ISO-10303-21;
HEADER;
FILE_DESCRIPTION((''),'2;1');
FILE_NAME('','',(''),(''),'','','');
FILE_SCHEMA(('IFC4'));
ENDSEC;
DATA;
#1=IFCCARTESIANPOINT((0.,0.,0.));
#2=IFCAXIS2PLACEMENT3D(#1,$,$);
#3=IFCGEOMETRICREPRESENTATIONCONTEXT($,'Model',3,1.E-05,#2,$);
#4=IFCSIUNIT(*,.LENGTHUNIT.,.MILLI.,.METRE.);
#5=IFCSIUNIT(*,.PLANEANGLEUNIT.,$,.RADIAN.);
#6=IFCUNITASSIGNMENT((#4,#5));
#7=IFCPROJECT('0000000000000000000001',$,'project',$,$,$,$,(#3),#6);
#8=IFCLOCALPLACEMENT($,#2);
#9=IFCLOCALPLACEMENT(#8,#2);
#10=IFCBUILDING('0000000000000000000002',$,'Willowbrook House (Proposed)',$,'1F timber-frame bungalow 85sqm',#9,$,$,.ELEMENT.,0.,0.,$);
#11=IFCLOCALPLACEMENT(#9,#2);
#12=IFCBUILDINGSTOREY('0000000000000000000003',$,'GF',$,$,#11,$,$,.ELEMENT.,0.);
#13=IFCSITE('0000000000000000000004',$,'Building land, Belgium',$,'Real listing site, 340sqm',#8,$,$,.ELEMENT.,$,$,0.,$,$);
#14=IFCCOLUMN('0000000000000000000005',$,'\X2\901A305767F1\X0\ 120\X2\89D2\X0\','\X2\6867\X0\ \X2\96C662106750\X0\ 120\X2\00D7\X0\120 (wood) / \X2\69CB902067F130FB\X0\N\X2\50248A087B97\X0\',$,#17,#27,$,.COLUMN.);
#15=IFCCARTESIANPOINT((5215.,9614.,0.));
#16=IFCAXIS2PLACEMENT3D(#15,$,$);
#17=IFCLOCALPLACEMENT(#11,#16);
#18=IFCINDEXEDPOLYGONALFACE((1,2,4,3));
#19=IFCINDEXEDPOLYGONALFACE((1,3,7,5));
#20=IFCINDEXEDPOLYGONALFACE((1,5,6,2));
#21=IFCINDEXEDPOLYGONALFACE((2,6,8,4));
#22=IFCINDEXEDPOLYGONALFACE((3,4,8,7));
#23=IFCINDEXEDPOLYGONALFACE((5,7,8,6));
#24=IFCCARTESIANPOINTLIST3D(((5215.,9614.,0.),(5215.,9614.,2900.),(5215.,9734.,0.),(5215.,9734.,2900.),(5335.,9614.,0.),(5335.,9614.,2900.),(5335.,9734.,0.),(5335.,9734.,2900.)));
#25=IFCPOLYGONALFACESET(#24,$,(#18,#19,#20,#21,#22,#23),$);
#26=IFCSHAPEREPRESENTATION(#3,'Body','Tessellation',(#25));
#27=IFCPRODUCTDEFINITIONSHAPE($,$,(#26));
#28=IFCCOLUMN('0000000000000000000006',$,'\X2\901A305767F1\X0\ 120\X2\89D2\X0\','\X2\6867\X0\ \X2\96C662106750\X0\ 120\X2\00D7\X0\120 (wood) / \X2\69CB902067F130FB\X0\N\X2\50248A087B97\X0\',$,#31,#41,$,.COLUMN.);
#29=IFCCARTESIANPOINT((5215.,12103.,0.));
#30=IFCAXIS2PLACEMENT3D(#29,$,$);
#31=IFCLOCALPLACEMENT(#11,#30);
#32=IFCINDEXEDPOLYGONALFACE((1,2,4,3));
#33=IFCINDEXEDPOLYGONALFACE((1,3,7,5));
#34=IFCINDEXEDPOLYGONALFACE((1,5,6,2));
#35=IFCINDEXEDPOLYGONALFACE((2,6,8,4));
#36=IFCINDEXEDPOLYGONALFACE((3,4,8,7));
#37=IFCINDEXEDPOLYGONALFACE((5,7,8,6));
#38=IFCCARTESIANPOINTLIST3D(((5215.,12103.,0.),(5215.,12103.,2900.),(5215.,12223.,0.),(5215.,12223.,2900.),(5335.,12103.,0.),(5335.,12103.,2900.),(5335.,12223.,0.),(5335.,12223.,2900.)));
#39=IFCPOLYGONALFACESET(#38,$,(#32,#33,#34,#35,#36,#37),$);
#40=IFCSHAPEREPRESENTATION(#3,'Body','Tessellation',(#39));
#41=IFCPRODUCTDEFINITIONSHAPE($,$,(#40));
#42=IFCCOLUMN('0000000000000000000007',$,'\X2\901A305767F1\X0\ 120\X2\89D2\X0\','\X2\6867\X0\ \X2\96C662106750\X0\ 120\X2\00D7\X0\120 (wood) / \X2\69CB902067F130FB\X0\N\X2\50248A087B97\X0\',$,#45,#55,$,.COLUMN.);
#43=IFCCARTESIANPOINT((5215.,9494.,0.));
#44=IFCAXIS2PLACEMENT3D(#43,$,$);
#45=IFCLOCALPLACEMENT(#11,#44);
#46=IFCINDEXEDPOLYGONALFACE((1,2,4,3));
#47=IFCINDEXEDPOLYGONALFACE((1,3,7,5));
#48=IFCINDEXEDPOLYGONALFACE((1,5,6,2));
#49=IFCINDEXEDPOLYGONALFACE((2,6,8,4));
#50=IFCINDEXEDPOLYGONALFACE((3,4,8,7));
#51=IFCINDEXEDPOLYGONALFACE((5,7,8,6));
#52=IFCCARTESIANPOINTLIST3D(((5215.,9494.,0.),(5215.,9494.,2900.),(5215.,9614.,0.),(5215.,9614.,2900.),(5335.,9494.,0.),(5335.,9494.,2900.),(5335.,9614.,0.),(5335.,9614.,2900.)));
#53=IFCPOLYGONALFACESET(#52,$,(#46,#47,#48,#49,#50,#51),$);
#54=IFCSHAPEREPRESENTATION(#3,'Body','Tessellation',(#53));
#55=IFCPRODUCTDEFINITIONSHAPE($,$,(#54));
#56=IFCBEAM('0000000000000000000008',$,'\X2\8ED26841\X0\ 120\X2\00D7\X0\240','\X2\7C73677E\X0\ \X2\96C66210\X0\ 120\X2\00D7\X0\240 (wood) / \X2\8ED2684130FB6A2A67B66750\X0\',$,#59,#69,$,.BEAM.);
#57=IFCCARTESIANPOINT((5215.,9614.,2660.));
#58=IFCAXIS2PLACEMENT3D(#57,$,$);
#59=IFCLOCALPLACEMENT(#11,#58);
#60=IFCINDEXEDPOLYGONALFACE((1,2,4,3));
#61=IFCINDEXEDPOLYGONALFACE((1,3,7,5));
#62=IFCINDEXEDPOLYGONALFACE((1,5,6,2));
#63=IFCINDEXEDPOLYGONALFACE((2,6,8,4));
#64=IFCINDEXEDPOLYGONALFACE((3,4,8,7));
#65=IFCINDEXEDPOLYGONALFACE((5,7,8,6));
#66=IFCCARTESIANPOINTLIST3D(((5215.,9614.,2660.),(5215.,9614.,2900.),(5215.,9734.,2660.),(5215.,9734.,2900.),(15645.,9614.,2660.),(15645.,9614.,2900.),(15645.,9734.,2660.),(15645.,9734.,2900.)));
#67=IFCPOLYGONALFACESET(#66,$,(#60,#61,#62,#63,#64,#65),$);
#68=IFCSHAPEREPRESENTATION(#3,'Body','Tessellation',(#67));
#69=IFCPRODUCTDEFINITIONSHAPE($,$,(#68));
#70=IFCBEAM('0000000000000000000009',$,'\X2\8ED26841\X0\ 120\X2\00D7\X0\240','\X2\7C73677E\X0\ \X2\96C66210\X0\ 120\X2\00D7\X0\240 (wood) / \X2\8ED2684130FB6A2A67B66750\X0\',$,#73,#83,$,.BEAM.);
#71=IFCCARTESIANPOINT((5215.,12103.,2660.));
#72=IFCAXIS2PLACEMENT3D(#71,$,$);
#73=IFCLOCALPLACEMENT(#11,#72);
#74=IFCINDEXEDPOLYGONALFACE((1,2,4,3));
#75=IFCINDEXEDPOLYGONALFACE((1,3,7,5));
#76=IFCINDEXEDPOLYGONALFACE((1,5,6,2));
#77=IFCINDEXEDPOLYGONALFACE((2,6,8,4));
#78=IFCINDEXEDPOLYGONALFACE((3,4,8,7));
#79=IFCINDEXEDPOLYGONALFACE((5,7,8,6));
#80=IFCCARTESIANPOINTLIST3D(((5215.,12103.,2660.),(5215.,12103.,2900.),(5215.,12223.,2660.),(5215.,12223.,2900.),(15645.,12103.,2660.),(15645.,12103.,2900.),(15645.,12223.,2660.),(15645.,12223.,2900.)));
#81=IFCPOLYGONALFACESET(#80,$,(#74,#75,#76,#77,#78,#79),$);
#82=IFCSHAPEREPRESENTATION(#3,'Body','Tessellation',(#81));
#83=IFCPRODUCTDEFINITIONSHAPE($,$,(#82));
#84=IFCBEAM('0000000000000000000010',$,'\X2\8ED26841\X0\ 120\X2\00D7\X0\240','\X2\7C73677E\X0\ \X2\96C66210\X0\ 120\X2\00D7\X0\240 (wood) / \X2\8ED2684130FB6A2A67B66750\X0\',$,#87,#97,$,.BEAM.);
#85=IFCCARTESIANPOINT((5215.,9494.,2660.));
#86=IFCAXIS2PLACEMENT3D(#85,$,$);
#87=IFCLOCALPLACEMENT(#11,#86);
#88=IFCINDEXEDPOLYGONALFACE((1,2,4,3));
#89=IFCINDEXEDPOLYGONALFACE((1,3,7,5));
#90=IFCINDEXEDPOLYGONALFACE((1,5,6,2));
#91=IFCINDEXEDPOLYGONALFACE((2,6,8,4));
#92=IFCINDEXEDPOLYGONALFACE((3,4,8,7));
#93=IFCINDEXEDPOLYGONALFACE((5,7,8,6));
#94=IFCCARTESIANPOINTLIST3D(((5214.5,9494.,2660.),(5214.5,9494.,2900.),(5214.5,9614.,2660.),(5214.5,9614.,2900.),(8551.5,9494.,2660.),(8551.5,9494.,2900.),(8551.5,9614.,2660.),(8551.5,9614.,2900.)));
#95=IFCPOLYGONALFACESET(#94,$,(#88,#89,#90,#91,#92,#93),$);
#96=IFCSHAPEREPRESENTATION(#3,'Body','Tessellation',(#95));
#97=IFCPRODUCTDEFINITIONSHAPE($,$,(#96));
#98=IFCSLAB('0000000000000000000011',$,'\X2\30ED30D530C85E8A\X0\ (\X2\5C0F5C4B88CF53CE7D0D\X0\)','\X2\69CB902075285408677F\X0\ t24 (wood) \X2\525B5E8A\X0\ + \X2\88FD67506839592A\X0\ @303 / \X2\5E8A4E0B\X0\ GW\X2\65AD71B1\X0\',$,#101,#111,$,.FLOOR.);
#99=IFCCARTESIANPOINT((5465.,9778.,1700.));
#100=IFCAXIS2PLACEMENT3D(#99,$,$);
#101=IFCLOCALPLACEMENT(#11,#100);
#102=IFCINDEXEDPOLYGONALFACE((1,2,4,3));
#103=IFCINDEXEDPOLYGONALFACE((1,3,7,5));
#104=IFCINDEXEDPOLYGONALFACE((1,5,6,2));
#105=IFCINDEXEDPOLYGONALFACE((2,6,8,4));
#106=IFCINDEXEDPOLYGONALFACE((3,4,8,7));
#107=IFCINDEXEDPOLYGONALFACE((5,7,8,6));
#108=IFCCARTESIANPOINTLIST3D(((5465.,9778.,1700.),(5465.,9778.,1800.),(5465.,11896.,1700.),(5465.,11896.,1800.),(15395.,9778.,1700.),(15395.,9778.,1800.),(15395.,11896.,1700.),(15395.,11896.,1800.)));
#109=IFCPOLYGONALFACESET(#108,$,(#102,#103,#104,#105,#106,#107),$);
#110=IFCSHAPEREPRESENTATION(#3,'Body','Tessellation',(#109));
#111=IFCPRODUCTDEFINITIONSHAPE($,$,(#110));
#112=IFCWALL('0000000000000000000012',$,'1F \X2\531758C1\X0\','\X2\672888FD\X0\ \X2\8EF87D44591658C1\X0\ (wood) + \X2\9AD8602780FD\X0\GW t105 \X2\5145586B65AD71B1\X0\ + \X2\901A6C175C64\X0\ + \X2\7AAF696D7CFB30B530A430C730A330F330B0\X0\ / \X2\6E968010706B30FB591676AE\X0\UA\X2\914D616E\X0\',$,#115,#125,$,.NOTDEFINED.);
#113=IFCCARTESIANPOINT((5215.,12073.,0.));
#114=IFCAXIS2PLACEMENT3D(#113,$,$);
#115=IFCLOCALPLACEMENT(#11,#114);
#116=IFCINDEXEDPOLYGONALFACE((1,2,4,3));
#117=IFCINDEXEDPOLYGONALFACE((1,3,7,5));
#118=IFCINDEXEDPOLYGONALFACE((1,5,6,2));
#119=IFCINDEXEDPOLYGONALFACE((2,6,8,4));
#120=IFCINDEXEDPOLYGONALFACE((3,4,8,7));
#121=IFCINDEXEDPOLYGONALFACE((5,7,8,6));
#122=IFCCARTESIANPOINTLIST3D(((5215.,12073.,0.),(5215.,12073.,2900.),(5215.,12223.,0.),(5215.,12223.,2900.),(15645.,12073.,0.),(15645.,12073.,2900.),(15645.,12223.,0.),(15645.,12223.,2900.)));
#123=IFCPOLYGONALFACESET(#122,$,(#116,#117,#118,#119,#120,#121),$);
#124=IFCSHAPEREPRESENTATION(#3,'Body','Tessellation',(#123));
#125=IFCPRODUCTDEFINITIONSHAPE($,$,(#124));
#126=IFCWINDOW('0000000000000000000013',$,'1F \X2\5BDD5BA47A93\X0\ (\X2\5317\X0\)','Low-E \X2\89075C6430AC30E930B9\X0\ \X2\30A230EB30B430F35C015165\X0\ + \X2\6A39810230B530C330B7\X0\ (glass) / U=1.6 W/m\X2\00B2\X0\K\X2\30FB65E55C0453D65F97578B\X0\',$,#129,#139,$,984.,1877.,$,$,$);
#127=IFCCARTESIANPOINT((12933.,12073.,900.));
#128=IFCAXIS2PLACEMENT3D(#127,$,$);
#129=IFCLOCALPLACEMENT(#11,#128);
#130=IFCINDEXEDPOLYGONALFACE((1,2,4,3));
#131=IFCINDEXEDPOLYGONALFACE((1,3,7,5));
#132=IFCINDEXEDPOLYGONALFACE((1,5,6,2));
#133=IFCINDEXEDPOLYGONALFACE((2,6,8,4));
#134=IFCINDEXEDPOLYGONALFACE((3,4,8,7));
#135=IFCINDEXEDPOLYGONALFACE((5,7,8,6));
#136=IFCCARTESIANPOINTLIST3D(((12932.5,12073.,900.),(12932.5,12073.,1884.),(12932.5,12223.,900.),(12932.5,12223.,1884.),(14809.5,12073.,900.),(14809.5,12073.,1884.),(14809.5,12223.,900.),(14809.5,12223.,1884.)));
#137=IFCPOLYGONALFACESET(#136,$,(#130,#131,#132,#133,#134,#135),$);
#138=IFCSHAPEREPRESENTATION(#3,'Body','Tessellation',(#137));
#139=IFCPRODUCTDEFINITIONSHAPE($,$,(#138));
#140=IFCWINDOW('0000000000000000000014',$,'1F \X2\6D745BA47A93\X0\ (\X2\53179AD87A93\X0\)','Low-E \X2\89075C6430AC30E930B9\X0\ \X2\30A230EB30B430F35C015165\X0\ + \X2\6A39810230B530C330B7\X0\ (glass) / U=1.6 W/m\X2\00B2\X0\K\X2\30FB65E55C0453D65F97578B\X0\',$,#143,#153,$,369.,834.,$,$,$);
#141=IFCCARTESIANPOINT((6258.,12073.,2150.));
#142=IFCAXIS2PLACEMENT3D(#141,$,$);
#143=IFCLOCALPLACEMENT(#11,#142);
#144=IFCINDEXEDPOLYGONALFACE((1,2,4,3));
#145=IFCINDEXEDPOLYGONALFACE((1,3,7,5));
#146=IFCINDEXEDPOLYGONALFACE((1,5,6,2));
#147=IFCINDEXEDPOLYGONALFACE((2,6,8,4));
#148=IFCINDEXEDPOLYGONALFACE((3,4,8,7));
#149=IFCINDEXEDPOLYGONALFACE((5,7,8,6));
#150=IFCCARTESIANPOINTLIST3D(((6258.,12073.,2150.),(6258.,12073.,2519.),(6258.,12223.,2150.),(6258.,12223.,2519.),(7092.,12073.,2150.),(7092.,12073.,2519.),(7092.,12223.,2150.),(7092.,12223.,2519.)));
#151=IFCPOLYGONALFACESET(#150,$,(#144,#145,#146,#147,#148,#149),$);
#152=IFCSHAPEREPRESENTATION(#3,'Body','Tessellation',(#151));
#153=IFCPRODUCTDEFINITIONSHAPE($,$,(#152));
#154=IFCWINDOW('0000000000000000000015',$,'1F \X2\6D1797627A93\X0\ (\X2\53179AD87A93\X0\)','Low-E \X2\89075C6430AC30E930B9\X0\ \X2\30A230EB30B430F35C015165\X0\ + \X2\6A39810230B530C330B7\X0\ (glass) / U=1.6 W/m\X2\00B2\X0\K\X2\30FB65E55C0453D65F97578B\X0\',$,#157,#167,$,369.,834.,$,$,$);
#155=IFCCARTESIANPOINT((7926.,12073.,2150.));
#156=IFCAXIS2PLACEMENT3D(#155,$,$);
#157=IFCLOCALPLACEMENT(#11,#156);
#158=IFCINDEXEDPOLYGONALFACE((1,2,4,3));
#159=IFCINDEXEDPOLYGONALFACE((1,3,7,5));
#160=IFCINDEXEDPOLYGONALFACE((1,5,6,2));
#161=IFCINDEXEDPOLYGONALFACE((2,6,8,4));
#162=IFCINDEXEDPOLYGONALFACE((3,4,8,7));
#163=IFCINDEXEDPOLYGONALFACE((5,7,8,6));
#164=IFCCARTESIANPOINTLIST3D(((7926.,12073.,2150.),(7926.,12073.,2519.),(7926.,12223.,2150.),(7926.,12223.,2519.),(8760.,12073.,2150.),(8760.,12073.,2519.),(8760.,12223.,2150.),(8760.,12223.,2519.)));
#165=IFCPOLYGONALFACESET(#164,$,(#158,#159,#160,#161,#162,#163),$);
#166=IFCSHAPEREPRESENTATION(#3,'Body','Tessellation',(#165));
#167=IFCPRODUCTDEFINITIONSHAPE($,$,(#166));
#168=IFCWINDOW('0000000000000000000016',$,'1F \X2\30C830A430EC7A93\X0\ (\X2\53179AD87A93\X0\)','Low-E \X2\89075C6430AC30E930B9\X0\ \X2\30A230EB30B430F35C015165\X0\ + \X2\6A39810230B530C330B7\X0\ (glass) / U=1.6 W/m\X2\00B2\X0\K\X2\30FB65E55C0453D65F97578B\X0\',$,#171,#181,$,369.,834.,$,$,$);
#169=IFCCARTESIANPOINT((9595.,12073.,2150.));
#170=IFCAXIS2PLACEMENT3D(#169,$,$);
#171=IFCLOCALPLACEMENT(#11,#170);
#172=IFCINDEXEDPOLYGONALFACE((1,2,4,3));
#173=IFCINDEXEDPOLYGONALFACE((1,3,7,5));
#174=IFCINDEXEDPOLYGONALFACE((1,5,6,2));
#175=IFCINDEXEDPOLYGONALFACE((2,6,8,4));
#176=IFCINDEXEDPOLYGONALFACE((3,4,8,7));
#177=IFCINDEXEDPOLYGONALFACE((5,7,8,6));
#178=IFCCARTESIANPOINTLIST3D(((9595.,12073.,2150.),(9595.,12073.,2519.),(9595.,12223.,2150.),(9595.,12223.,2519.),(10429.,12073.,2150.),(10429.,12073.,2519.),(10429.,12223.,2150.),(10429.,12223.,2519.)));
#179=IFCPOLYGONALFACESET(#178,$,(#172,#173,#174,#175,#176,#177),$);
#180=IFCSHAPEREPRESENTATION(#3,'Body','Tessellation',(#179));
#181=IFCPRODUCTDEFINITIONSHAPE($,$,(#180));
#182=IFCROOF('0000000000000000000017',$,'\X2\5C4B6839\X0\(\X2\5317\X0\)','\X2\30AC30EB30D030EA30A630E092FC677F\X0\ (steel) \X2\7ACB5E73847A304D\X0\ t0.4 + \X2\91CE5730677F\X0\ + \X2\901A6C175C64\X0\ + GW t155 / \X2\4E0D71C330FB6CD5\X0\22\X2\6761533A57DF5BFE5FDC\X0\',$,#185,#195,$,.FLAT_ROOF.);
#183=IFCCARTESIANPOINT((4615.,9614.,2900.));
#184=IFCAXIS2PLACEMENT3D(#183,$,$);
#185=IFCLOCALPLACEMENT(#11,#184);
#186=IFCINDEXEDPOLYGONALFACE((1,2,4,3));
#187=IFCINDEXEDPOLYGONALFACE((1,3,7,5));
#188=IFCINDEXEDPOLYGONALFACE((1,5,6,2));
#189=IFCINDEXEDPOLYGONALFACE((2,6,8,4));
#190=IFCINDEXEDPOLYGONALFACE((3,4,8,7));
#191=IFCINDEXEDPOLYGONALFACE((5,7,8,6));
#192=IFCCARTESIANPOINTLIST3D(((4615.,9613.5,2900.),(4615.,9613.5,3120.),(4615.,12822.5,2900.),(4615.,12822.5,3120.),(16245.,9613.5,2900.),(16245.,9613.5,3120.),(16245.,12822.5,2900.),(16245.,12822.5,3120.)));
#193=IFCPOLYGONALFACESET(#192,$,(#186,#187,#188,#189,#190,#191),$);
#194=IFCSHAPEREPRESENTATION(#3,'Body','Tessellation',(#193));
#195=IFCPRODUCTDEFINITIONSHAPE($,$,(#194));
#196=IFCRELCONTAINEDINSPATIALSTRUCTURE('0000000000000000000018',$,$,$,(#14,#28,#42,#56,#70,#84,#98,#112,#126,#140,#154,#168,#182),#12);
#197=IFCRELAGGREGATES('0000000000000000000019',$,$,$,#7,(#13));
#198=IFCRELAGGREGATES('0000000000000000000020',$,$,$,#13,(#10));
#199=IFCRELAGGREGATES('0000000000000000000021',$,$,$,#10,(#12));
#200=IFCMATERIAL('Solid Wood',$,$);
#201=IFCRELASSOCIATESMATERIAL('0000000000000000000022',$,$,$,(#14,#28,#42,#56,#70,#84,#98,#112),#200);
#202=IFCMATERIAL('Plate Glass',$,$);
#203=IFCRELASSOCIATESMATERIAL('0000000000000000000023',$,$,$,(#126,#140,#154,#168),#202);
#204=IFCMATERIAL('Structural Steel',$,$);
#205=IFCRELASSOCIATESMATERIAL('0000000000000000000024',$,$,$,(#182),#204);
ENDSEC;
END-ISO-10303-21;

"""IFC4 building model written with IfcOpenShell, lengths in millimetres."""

from ifc_helpers import new_model, si_unit, frame, frame_2d, origin, place, context, project, spatial, rectangle, extrude, material, element, fill, save


model = new_model("IFC4")

# Units and contexts
model_context = context("Model", 3, precision=1e-05, world=origin())
ifc_project = project(units=[si_unit("LENGTHUNIT", "METRE", prefix="MILLI"), si_unit("PLANEANGLEUNIT", "RADIAN")], contexts=[model_context])

# Site, building, storey
site_placement = place(None, origin())
site = spatial("IfcSite", under=ifc_project, at=site_placement, Name="Building land, Belgium", ObjectType="Real listing site, 340sqm", CompositionType="ELEMENT", RefElevation=0.0)
building_placement = place(site_placement, origin())
building = spatial("IfcBuilding", under=site, at=building_placement, Name="Willowbrook House (Proposed)", ObjectType="1F timber-frame bungalow 85sqm", CompositionType="ELEMENT", ElevationOfRefHeight=0.0, ElevationOfTerrain=0.0)
storey_placement = place(building_placement, origin())
storey = spatial("IfcBuildingStorey", under=building, at=storey_placement, Name="GF", CompositionType="ELEMENT", Elevation=0.0)

# Columns
ifc_material_1 = material(Name="Solid Wood")
column_1_placement = place(storey_placement, frame((5215.0, 9614.0, 0.0)))
element("IfcColumn", 1, at=column_1_placement, inside=storey, material=ifc_material_1, Name="通し柱 120角", Description="桧 集成材 120×120 (wood) / 構造柱・N値計算", PredefinedType="COLUMN", context=model_context, shape_type="SweptSolid", body=[
    extrude(rectangle(XDim=120.0, YDim=120.0, at=frame_2d((60.0, 60.0))), frame((5215.0, 9614.0, 0.0)), (0.0, 0.0, 1.0), 2900.0),
])
column_2_placement = place(storey_placement, frame((5215.0, 12103.0, 0.0)))
element("IfcColumn", 2, at=column_2_placement, inside=storey, material=ifc_material_1, Name="通し柱 120角", Description="桧 集成材 120×120 (wood) / 構造柱・N値計算", PredefinedType="COLUMN", context=model_context, shape_type="SweptSolid", body=[
    extrude(rectangle(XDim=120.0, YDim=120.0, at=frame_2d((60.0, 60.0))), frame((5215.0, 12103.0, 0.0)), (0.0, 0.0, 1.0), 2900.0),
])
column_3_placement = place(storey_placement, frame((5215.0, 9494.0, 0.0)))
element("IfcColumn", 3, at=column_3_placement, inside=storey, material=ifc_material_1, Name="通し柱 120角", Description="桧 集成材 120×120 (wood) / 構造柱・N値計算", PredefinedType="COLUMN", context=model_context, shape_type="SweptSolid", body=[
    extrude(rectangle(XDim=120.0, YDim=120.0, at=frame_2d((60.0, 60.0))), frame((5215.0, 9494.0, 0.0)), (0.0, 0.0, 1.0), 2900.0),
])

# Beams
beam_1_placement = place(storey_placement, frame((5215.0, 9614.0, 2660.0)))
element("IfcBeam", 4, at=beam_1_placement, inside=storey, material=ifc_material_1, Name="軒桁 120×240", Description="米松 集成 120×240 (wood) / 軒桁・横架材", PredefinedType="BEAM", context=model_context, shape_type="SweptSolid", body=[
    extrude(rectangle(XDim=10430.0, YDim=120.0, at=frame_2d((5215.0, 60.0))), frame((5215.0, 9614.0, 2660.0)), (0.0, 0.0, 1.0), 240.0),
])
beam_2_placement = place(storey_placement, frame((5215.0, 12103.0, 2660.0)))
element("IfcBeam", 5, at=beam_2_placement, inside=storey, material=ifc_material_1, Name="軒桁 120×240", Description="米松 集成 120×240 (wood) / 軒桁・横架材", PredefinedType="BEAM", context=model_context, shape_type="SweptSolid", body=[
    extrude(rectangle(XDim=10430.0, YDim=120.0, at=frame_2d((5215.0, 60.0))), frame((5215.0, 12103.0, 2660.0)), (0.0, 0.0, 1.0), 240.0),
])
beam_3_placement = place(storey_placement, frame((5215.0, 9494.0, 2660.0)))
element("IfcBeam", 6, at=beam_3_placement, inside=storey, material=ifc_material_1, Name="軒桁 120×240", Description="米松 集成 120×240 (wood) / 軒桁・横架材", PredefinedType="BEAM", context=model_context, shape_type="SweptSolid", body=[
    extrude(rectangle(XDim=3337.0, YDim=120.0, at=frame_2d((1668.0, 60.0))), frame((5215.0, 9494.0, 2660.0)), (0.0, 0.0, 1.0), 240.0),
])

# Slab
slab_1_placement = place(storey_placement, frame((5465.0, 9778.0, 1700.0)))
element("IfcSlab", 7, at=slab_1_placement, inside=storey, material=ifc_material_1, Name="ロフト床 (小屋裏収納)", Description="構造用合板 t24 (wood) 剛床 + 製材根太 @303 / 床下 GW断熱", PredefinedType="FLOOR", context=model_context, shape_type="SweptSolid", body=[
    extrude(rectangle(XDim=9930.0, YDim=2118.0, at=frame_2d((4965.0, 1059.0))), frame((5465.0, 9778.0, 1700.0)), (0.0, 0.0, 1.0), 100.0),
])

# Wall, openings, windows
wall_1_placement = place(storey_placement, frame((5215.0, 12073.0, 0.0)))
wall_1 = element("IfcWall", 8, at=wall_1_placement, inside=storey, material=ifc_material_1, Name="1F 北壁", Description="木製 軸組外壁 (wood) + 高性能GW t105 充填断熱 + 通気層 + 窯業系サイディング / 準耐火・外皮UA配慮", PredefinedType="NOTDEFINED", context=model_context, shape_type="SweptSolid", body=[
    extrude(rectangle(XDim=10430.0, YDim=150.0, at=frame_2d((5215.0, 75.0))), frame((5215.0, 12073.0, 0.0)), (0.0, 0.0, 1.0), 2900.0),
])
opening_1_placement = place(storey_placement, frame((12933.0, 12073.0, 900.0)))
opening_1 = element("IfcOpeningElement", 9, at=opening_1_placement, cuts=wall_1, PredefinedType="NOTDEFINED", context=model_context, shape_type="SweptSolid", body=[
    extrude(rectangle(XDim=1877.0, YDim=150.0, at=frame_2d((938.0, 75.0))), frame((12933.0, 12073.0, 900.0)), (0.0, 0.0, 1.0), 984.0),
])
opening_2_placement = place(storey_placement, frame((6258.0, 12073.0, 2150.0)))
opening_2 = element("IfcOpeningElement", 10, at=opening_2_placement, cuts=wall_1, PredefinedType="NOTDEFINED", context=model_context, shape_type="SweptSolid", body=[
    extrude(rectangle(XDim=834.0, YDim=150.0, at=frame_2d((417.0, 75.0))), frame((6258.0, 12073.0, 2150.0)), (0.0, 0.0, 1.0), 369.0),
])
opening_3_placement = place(storey_placement, frame((7926.0, 12073.0, 2150.0)))
opening_3 = element("IfcOpeningElement", 11, at=opening_3_placement, cuts=wall_1, PredefinedType="NOTDEFINED", context=model_context, shape_type="SweptSolid", body=[
    extrude(rectangle(XDim=834.0, YDim=150.0, at=frame_2d((417.0, 75.0))), frame((7926.0, 12073.0, 2150.0)), (0.0, 0.0, 1.0), 369.0),
])
opening_4_placement = place(storey_placement, frame((9595.0, 12073.0, 2150.0)))
opening_4 = element("IfcOpeningElement", 12, at=opening_4_placement, cuts=wall_1, PredefinedType="NOTDEFINED", context=model_context, shape_type="SweptSolid", body=[
    extrude(rectangle(XDim=834.0, YDim=150.0, at=frame_2d((417.0, 75.0))), frame((9595.0, 12073.0, 2150.0)), (0.0, 0.0, 1.0), 369.0),
])
ifc_material_2 = material(Name="Plate Glass")
window_1_placement = place(storey_placement, frame((12933.0, 12073.0, 900.0)))
window_1 = element("IfcWindow", 13, at=window_1_placement, inside=storey, material=ifc_material_2, Name="1F 寝室窓 (北)", Description="Low-E 複層ガラス アルゴン封入 + 樹脂サッシ (glass) / U=1.6 W/m²K・日射取得型", OverallHeight=984.0, OverallWidth=1877.0, context=model_context, shape_type="SweptSolid", body=[
    extrude(rectangle(XDim=1877.0, YDim=150.0, at=frame_2d((938.0, 75.0))), frame((12933.0, 12073.0, 900.0)), (0.0, 0.0, 1.0), 984.0),
])
fill(opening_1, window_1)
window_2_placement = place(storey_placement, frame((6258.0, 12073.0, 2150.0)))
window_2 = element("IfcWindow", 14, at=window_2_placement, inside=storey, material=ifc_material_2, Name="1F 浴室窓 (北高窓)", Description="Low-E 複層ガラス アルゴン封入 + 樹脂サッシ (glass) / U=1.6 W/m²K・日射取得型", OverallHeight=369.0, OverallWidth=834.0, context=model_context, shape_type="SweptSolid", body=[
    extrude(rectangle(XDim=834.0, YDim=150.0, at=frame_2d((417.0, 75.0))), frame((6258.0, 12073.0, 2150.0)), (0.0, 0.0, 1.0), 369.0),
])
fill(opening_2, window_2)
window_3_placement = place(storey_placement, frame((7926.0, 12073.0, 2150.0)))
window_3 = element("IfcWindow", 15, at=window_3_placement, inside=storey, material=ifc_material_2, Name="1F 洗面窓 (北高窓)", Description="Low-E 複層ガラス アルゴン封入 + 樹脂サッシ (glass) / U=1.6 W/m²K・日射取得型", OverallHeight=369.0, OverallWidth=834.0, context=model_context, shape_type="SweptSolid", body=[
    extrude(rectangle(XDim=834.0, YDim=150.0, at=frame_2d((417.0, 75.0))), frame((7926.0, 12073.0, 2150.0)), (0.0, 0.0, 1.0), 369.0),
])
fill(opening_3, window_3)
window_4_placement = place(storey_placement, frame((9595.0, 12073.0, 2150.0)))
window_4 = element("IfcWindow", 16, at=window_4_placement, inside=storey, material=ifc_material_2, Name="1F トイレ窓 (北高窓)", Description="Low-E 複層ガラス アルゴン封入 + 樹脂サッシ (glass) / U=1.6 W/m²K・日射取得型", OverallHeight=369.0, OverallWidth=834.0, context=model_context, shape_type="SweptSolid", body=[
    extrude(rectangle(XDim=834.0, YDim=150.0, at=frame_2d((417.0, 75.0))), frame((9595.0, 12073.0, 2150.0)), (0.0, 0.0, 1.0), 369.0),
])
fill(opening_4, window_4)

# Roof
ifc_material_3 = material(Name="Structural Steel")
roof_placement = place(storey_placement, frame((4615.0, 9614.0, 2900.0)))
element("IfcRoof", 17, at=roof_placement, inside=storey, material=ifc_material_3, Name="屋根(北)", Description="ガルバリウム鋼板 (steel) 立平葺き t0.4 + 野地板 + 通気層 + GW t155 / 不燃・法22条区域対応", PredefinedType="FLAT_ROOF", context=model_context, shape_type="SweptSolid", body=[
    extrude(rectangle(XDim=11630.0, YDim=3209.0, at=frame_2d((5815.0, 1604.0))), frame((4615.0, 9614.0, 2900.0)), (0.0, 0.0, 1.0), 220.0),
])

save(model, "model.ifc")
